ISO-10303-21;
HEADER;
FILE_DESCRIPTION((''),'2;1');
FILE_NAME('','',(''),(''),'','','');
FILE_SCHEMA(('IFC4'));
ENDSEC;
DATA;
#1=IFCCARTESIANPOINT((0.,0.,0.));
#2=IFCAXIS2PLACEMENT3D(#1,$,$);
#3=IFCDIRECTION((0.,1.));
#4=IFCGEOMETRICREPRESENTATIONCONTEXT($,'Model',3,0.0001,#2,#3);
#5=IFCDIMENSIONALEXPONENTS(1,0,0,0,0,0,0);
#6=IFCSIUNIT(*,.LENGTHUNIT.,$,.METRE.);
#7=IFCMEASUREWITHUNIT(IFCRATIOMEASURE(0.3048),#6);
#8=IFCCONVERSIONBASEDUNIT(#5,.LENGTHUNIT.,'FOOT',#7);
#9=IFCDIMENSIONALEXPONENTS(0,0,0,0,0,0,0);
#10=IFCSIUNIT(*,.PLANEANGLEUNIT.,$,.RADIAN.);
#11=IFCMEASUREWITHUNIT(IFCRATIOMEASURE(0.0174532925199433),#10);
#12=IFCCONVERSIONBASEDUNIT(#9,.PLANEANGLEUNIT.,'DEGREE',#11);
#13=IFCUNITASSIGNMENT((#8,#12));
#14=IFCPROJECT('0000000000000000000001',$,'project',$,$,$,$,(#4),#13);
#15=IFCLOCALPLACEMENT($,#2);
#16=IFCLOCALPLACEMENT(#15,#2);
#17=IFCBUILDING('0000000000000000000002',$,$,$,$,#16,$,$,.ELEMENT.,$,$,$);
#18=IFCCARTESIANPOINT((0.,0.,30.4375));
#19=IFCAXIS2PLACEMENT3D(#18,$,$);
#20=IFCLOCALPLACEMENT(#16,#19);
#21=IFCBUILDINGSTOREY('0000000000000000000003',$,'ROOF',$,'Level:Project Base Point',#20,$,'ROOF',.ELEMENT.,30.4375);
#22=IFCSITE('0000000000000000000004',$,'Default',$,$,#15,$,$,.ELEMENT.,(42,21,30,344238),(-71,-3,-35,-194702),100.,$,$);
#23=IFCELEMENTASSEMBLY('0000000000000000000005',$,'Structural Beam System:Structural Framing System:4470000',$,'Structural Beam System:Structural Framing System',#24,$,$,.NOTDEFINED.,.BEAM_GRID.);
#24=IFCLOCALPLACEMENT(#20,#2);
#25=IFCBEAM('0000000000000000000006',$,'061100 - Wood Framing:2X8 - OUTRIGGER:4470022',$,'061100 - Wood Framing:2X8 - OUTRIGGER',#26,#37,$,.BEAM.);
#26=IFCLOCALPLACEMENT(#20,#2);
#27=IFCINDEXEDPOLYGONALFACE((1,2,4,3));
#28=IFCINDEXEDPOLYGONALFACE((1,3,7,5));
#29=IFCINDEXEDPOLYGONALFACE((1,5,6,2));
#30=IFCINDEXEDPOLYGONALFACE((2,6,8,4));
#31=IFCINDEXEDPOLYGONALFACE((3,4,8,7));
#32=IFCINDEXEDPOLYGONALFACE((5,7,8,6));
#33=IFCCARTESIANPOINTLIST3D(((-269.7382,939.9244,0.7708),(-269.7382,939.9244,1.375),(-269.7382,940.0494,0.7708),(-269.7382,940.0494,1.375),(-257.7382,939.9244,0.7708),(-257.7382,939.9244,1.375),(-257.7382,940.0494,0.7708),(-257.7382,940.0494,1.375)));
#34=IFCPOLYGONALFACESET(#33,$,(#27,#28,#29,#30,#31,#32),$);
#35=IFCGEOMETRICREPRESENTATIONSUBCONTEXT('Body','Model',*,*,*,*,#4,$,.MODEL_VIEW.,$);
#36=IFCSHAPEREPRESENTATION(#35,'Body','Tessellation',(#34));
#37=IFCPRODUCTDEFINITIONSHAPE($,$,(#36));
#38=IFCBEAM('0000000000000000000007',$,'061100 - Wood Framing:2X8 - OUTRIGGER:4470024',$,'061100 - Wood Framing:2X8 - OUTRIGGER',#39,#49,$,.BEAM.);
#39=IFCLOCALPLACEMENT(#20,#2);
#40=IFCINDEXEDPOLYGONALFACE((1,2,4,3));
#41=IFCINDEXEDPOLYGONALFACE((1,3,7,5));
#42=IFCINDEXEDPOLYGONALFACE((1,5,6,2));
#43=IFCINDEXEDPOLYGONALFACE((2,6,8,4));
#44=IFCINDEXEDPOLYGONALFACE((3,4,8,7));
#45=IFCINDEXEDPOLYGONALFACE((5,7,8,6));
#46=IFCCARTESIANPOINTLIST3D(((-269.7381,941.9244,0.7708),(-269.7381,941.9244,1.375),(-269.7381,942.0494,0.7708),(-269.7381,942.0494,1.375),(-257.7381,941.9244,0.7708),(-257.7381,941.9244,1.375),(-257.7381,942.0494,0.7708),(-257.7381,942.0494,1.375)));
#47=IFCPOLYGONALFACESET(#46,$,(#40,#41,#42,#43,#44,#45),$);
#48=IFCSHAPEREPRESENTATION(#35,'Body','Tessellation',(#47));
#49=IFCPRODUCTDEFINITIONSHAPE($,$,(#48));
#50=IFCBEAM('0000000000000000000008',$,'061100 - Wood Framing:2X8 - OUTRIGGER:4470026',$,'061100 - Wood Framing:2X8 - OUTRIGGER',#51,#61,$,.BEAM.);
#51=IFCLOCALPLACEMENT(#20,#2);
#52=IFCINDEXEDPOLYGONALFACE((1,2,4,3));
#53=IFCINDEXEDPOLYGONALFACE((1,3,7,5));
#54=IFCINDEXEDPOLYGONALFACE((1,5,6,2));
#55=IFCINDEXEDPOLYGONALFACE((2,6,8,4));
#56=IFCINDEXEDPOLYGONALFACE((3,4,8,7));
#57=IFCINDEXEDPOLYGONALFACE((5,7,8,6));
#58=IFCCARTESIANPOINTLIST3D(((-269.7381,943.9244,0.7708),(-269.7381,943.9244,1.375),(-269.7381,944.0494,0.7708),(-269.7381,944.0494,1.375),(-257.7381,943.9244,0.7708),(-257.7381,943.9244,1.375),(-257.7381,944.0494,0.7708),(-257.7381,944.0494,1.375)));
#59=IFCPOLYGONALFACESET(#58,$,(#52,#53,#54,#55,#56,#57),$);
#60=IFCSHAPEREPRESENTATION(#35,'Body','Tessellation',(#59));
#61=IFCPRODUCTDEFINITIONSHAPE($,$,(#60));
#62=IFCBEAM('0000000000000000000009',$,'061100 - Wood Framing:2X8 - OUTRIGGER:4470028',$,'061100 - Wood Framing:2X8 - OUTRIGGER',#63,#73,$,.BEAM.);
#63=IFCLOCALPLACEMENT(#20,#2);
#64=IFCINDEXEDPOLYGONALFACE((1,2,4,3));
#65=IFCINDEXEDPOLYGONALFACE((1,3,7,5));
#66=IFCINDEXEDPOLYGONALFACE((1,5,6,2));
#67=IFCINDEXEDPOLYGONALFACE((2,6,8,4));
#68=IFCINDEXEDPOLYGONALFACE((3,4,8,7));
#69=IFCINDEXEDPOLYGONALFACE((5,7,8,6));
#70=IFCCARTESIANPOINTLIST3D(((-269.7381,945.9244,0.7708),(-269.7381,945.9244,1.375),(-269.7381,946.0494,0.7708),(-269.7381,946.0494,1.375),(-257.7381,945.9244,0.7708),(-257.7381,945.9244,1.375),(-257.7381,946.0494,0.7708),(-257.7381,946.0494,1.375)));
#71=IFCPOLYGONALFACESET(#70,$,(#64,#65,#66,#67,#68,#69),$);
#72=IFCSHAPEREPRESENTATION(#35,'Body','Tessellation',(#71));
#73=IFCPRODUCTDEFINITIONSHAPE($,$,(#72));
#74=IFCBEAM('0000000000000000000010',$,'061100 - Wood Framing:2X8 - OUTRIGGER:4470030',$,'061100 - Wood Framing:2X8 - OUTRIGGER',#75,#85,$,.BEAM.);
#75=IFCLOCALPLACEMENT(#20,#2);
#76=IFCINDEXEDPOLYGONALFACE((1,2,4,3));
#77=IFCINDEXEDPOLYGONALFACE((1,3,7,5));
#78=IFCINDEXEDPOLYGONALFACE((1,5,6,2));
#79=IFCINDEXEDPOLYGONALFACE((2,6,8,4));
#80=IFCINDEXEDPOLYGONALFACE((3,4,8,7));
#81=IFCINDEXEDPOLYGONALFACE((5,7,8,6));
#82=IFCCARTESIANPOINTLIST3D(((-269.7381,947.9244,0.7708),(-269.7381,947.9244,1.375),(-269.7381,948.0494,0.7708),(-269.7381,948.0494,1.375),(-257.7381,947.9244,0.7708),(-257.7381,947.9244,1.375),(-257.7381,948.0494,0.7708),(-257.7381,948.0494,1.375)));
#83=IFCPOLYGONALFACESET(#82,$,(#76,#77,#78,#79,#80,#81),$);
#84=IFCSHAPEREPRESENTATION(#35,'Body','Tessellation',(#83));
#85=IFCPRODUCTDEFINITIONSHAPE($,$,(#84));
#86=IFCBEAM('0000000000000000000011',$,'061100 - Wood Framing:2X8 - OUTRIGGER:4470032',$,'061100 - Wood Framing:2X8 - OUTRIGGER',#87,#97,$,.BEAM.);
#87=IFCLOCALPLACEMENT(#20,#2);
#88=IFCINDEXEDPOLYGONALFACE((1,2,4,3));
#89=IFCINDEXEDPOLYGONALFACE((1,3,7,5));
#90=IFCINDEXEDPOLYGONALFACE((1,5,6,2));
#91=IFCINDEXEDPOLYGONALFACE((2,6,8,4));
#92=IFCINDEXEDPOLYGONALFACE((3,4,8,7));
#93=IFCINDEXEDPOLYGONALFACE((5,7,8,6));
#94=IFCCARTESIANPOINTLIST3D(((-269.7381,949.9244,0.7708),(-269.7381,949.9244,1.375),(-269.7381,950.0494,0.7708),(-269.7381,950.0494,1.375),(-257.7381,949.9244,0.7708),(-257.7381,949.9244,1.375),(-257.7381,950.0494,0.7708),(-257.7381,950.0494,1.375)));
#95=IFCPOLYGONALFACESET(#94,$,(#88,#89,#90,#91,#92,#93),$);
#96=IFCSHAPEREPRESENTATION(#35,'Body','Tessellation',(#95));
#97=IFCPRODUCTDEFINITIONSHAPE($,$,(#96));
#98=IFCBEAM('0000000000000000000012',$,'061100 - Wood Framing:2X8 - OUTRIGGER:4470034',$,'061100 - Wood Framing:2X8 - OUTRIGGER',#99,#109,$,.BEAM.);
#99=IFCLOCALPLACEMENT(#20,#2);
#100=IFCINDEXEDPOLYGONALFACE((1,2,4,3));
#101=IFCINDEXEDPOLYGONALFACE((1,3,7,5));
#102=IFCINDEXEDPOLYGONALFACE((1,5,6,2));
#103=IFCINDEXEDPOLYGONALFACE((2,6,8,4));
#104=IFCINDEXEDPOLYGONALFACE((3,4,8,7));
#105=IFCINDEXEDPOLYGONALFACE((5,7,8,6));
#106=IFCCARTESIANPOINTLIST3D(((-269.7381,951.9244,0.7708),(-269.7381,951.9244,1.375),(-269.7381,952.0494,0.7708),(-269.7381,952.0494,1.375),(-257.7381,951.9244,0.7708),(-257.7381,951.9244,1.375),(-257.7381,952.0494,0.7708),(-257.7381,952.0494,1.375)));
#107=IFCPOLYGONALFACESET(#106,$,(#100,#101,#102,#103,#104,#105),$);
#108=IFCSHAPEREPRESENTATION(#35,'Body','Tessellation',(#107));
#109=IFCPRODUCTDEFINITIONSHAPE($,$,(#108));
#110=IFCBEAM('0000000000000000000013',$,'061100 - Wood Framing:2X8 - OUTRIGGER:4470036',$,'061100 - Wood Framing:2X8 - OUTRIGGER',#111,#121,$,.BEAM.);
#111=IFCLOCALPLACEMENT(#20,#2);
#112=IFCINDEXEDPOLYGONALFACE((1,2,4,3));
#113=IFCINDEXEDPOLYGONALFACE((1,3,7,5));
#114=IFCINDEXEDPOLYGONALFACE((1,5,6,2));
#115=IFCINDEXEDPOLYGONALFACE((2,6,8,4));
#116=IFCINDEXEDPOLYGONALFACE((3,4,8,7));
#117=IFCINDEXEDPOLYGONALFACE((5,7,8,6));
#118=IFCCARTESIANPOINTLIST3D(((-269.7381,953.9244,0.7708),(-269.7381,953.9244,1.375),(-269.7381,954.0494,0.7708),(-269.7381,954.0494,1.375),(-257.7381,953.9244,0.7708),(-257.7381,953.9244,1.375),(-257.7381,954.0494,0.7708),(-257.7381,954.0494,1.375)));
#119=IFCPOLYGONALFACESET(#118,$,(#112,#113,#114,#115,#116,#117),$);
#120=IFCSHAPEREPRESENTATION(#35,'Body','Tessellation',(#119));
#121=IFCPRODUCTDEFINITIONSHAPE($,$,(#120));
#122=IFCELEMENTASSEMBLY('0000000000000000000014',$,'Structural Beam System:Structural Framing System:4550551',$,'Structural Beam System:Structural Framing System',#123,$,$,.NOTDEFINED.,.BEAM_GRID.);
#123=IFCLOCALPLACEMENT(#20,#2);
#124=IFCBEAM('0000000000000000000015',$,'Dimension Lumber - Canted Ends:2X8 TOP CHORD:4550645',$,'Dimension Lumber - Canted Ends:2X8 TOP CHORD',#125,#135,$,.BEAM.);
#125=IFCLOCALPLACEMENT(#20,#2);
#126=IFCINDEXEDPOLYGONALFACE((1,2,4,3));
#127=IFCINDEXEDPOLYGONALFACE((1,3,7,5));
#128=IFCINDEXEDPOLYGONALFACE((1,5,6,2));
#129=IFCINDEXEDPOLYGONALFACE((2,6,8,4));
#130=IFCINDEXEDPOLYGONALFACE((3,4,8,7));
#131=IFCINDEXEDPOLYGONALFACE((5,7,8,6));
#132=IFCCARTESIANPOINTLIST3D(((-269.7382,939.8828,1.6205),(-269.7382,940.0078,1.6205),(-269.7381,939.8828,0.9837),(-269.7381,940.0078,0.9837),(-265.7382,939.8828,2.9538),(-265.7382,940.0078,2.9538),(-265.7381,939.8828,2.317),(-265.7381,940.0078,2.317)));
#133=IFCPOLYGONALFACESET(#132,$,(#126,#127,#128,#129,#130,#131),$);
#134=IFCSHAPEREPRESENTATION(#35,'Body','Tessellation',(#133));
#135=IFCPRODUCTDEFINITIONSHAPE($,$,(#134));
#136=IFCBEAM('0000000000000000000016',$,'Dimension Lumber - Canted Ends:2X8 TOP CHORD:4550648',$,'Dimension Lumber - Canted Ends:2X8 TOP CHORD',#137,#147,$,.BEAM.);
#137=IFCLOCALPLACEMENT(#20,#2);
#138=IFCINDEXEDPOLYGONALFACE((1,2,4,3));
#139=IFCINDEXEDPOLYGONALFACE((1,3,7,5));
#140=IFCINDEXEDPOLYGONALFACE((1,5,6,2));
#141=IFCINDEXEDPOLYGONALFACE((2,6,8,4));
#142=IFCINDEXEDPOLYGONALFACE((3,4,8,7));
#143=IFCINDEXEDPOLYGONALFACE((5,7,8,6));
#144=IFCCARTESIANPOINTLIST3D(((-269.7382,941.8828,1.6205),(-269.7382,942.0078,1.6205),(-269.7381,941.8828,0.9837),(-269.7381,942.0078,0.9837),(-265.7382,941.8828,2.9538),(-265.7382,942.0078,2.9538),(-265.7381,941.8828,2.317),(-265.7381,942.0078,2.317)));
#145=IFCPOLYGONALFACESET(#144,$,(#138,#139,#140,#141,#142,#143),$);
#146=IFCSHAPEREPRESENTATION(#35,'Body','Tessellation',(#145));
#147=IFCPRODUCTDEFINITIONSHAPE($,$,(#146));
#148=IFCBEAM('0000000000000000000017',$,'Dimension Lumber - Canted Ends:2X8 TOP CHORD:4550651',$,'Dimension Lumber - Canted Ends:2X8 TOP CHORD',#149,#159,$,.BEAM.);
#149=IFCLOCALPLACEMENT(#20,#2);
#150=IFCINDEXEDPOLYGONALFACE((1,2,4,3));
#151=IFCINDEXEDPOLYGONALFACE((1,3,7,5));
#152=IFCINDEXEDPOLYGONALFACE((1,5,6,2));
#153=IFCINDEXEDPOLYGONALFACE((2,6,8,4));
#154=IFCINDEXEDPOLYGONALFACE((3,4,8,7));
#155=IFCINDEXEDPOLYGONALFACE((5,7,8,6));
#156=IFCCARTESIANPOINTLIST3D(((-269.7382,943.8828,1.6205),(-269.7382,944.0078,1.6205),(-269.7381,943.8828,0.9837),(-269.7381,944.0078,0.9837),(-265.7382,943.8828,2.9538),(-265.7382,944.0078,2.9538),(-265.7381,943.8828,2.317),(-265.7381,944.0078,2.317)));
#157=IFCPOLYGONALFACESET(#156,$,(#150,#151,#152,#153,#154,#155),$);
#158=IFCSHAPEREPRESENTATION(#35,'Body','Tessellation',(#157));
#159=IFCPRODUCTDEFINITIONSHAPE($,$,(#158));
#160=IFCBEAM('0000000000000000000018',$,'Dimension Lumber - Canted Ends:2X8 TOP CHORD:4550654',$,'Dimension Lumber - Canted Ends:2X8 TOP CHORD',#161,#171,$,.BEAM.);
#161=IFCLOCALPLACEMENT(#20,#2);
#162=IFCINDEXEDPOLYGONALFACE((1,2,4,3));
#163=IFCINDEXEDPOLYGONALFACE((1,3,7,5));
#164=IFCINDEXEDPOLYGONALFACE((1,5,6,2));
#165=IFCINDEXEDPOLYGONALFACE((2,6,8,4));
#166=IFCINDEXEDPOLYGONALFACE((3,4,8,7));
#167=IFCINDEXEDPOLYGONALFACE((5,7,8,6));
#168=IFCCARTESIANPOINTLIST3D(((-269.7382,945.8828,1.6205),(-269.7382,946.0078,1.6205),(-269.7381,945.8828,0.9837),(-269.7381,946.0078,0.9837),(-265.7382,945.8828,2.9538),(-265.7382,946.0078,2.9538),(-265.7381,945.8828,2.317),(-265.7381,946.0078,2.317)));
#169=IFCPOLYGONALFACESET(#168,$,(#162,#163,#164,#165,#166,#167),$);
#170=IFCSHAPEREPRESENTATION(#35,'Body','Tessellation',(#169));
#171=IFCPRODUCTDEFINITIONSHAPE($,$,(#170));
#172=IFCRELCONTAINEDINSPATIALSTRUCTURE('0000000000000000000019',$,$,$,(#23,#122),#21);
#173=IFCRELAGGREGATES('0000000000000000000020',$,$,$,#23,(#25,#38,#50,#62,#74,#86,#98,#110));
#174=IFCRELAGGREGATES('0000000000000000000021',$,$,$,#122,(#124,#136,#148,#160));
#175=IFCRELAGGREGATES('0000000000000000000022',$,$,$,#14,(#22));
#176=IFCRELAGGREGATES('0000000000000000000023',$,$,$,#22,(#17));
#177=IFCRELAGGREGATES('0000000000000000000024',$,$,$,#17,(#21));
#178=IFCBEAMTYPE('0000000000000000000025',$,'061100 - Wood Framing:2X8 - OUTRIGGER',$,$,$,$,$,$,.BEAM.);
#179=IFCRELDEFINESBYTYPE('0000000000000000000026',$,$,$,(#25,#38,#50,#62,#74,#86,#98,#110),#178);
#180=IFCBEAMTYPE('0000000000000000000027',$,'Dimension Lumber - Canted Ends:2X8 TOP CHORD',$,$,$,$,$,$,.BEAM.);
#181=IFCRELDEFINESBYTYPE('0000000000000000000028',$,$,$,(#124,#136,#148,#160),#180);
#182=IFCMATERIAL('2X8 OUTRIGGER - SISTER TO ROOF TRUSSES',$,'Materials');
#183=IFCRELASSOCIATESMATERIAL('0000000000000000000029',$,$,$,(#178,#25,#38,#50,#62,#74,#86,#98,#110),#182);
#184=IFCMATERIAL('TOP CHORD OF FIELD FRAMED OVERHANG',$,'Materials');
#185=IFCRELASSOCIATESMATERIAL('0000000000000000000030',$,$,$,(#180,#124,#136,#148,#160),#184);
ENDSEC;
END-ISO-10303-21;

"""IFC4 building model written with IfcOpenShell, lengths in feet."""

from ifc_helpers import new_model, entity, si_unit, converted_unit, direction, frame, frame_2d, origin, origin_2d_with_axis, place, context, subcontext, project, spatial, rectangle, extrude, clip, halfspace, source, transform, mapped, material, material_profile, profile_set, profile_usage, type_object, type_shapes, element, aggregate, save


model = new_model("IFC4")

# Units and contexts
model_context = context("Model", 3, precision=0.0001, world=origin(), true_north=direction((0.0, 1.0)))
body_context = subcontext(model_context, "Body", "Model", "MODEL_VIEW")
ifc_project = project(units=[converted_unit("LENGTHUNIT", "FOOT", entity("IfcRatioMeasure", 0.3048), si_unit("LENGTHUNIT", "METRE"), dimensions=[1, 0, 0, 0, 0, 0, 0]), converted_unit("PLANEANGLEUNIT", "DEGREE", entity("IfcRatioMeasure", 0.0174532925199433), si_unit("PLANEANGLEUNIT", "RADIAN"), dimensions=[0, 0, 0, 0, 0, 0, 0])], contexts=[model_context])

# Site, building, storey
site_placement = place(None, origin())
site = spatial("IfcSite", under=ifc_project, at=site_placement, Name="Default", CompositionType="ELEMENT", RefLatitude=(42, 21, 30, 344238), RefLongitude=(-71, -3, -35, -194702), RefElevation=100.0)
building_placement = place(site_placement, origin())
building = spatial("IfcBuilding", under=site, at=building_placement, CompositionType="ELEMENT")
storey_placement = place(building_placement, frame((0.0, 0.0, 30.4375)))
storey = spatial("IfcBuildingStorey", under=building, at=storey_placement, Name="ROOF", ObjectType="Level:Project Base Point", LongName="ROOF", CompositionType="ELEMENT", Elevation=30.4375)

# Element assemblies, beams
assembly_1_placement = place(storey_placement, origin())
assembly_1 = element("IfcElementAssembly", 1, at=assembly_1_placement, inside=storey, Name="Structural Beam System:Structural Framing System:4470000", ObjectType="Structural Beam System:Structural Framing System", AssemblyPlace="NOTDEFINED", PredefinedType="BEAM_GRID")
ifc_material_1 = material(Name="2X8 OUTRIGGER - SISTER TO ROOF TRUSSES", Category="Materials")
ifc_material_profile_1 = material_profile(ifc_material_1, rectangle(XDim=0.6042, YDim=0.125, at=origin_2d_with_axis()), Name="2X8 - OUTRIGGER")
ifc_profile_set_1 = profile_set([ifc_material_profile_1], Name="2X8 - OUTRIGGER")
ifc_profile_usage_1 = profile_usage(ifc_profile_set_1, cardinal=8)
beam_type_1 = type_object("IfcBeamType", Name="061100 - Wood Framing:2X8 - OUTRIGGER", PredefinedType="BEAM", material=ifc_profile_set_1)
shared_shape_1 = source(origin(), body_context, "Body", "SweptSolid", [
    extrude(rectangle(XDim=0.6042, YDim=0.125, at=origin_2d_with_axis()), frame((-6.0, 0.0, 0.0), z_axis=(1.0, 0.0, 0.0), x_axis=(0.0, 0.0, -1.0)), (0.0, 0.0, 1.0), 12.0),
])
type_shapes(beam_type_1, [shared_shape_1])
beam_1_placement = place(assembly_1_placement, frame((-263.7382, 939.9869, 1.0729), z_axis=(0.0, 0.0, 1.0), x_axis=(-1.0, 0.0, 0.0)))
beam_1 = element("IfcBeam", 2, at=beam_1_placement, type_object=beam_type_1, material=ifc_profile_usage_1, Name="061100 - Wood Framing:2X8 - OUTRIGGER:4470022", ObjectType="061100 - Wood Framing:2X8 - OUTRIGGER", PredefinedType="BEAM", context=body_context, shape_type="MappedRepresentation", body=[
    mapped(shared_shape_1, transform((0.0, 0.0, 0.0), scale=1.0)),
])
ifc_profile_usage_2 = profile_usage(ifc_profile_set_1, cardinal=8)
beam_2_placement = place(assembly_1_placement, frame((-263.7381, 941.9869, 1.0729), z_axis=(0.0, 0.0, 1.0), x_axis=(-1.0, 0.0, 0.0)))
beam_2 = element("IfcBeam", 3, at=beam_2_placement, type_object=beam_type_1, material=ifc_profile_usage_2, Name="061100 - Wood Framing:2X8 - OUTRIGGER:4470024", ObjectType="061100 - Wood Framing:2X8 - OUTRIGGER", PredefinedType="BEAM", context=body_context, shape_type="MappedRepresentation", body=[
    mapped(shared_shape_1, transform((0.0, 0.0, 0.0), scale=1.0)),
])
ifc_profile_usage_3 = profile_usage(ifc_profile_set_1, cardinal=8)
beam_3_placement = place(assembly_1_placement, frame((-263.7381, 943.9869, 1.0729), z_axis=(0.0, 0.0, 1.0), x_axis=(-1.0, 0.0, 0.0)))
beam_3 = element("IfcBeam", 4, at=beam_3_placement, type_object=beam_type_1, material=ifc_profile_usage_3, Name="061100 - Wood Framing:2X8 - OUTRIGGER:4470026", ObjectType="061100 - Wood Framing:2X8 - OUTRIGGER", PredefinedType="BEAM", context=body_context, shape_type="MappedRepresentation", body=[
    mapped(shared_shape_1, transform((0.0, 0.0, 0.0), scale=1.0)),
])
ifc_profile_usage_4 = profile_usage(ifc_profile_set_1, cardinal=8)
beam_4_placement = place(assembly_1_placement, frame((-263.7381, 945.9869, 1.0729), z_axis=(0.0, 0.0, 1.0), x_axis=(-1.0, 0.0, 0.0)))
beam_4 = element("IfcBeam", 5, at=beam_4_placement, type_object=beam_type_1, material=ifc_profile_usage_4, Name="061100 - Wood Framing:2X8 - OUTRIGGER:4470028", ObjectType="061100 - Wood Framing:2X8 - OUTRIGGER", PredefinedType="BEAM", context=body_context, shape_type="MappedRepresentation", body=[
    mapped(shared_shape_1, transform((0.0, 0.0, 0.0), scale=1.0)),
])
ifc_profile_usage_5 = profile_usage(ifc_profile_set_1, cardinal=8)
beam_5_placement = place(assembly_1_placement, frame((-263.7381, 947.9869, 1.0729), z_axis=(0.0, 0.0, 1.0), x_axis=(-1.0, 0.0, 0.0)))
beam_5 = element("IfcBeam", 6, at=beam_5_placement, type_object=beam_type_1, material=ifc_profile_usage_5, Name="061100 - Wood Framing:2X8 - OUTRIGGER:4470030", ObjectType="061100 - Wood Framing:2X8 - OUTRIGGER", PredefinedType="BEAM", context=body_context, shape_type="MappedRepresentation", body=[
    mapped(shared_shape_1, transform((0.0, 0.0, 0.0), scale=1.0)),
])
ifc_profile_usage_6 = profile_usage(ifc_profile_set_1, cardinal=8)
beam_6_placement = place(assembly_1_placement, frame((-263.7381, 949.9869, 1.0729), z_axis=(0.0, 0.0, 1.0), x_axis=(-1.0, 0.0, 0.0)))
beam_6 = element("IfcBeam", 7, at=beam_6_placement, type_object=beam_type_1, material=ifc_profile_usage_6, Name="061100 - Wood Framing:2X8 - OUTRIGGER:4470032", ObjectType="061100 - Wood Framing:2X8 - OUTRIGGER", PredefinedType="BEAM", context=body_context, shape_type="MappedRepresentation", body=[
    mapped(shared_shape_1, transform((0.0, 0.0, 0.0), scale=1.0)),
])
ifc_profile_usage_7 = profile_usage(ifc_profile_set_1, cardinal=8)
beam_7_placement = place(assembly_1_placement, frame((-263.7381, 951.9869, 1.0729), z_axis=(0.0, 0.0, 1.0), x_axis=(-1.0, 0.0, 0.0)))
beam_7 = element("IfcBeam", 8, at=beam_7_placement, type_object=beam_type_1, material=ifc_profile_usage_7, Name="061100 - Wood Framing:2X8 - OUTRIGGER:4470034", ObjectType="061100 - Wood Framing:2X8 - OUTRIGGER", PredefinedType="BEAM", context=body_context, shape_type="MappedRepresentation", body=[
    mapped(shared_shape_1, transform((0.0, 0.0, 0.0), scale=1.0)),
])
ifc_profile_usage_8 = profile_usage(ifc_profile_set_1, cardinal=8)
beam_8_placement = place(assembly_1_placement, frame((-263.7381, 953.9869, 1.0729), z_axis=(0.0, 0.0, 1.0), x_axis=(-1.0, 0.0, 0.0)))
beam_8 = element("IfcBeam", 9, at=beam_8_placement, type_object=beam_type_1, material=ifc_profile_usage_8, Name="061100 - Wood Framing:2X8 - OUTRIGGER:4470036", ObjectType="061100 - Wood Framing:2X8 - OUTRIGGER", PredefinedType="BEAM", context=body_context, shape_type="MappedRepresentation", body=[
    mapped(shared_shape_1, transform((0.0, 0.0, 0.0), scale=1.0)),
])
aggregate(assembly_1, [beam_1, beam_2, beam_3, beam_4, beam_5, beam_6, beam_7, beam_8])
assembly_2_placement = place(storey_placement, origin())
assembly_2 = element("IfcElementAssembly", 10, at=assembly_2_placement, inside=storey, Name="Structural Beam System:Structural Framing System:4550551", ObjectType="Structural Beam System:Structural Framing System", AssemblyPlace="NOTDEFINED", PredefinedType="BEAM_GRID")
ifc_material_2 = material(Name="TOP CHORD OF FIELD FRAMED OVERHANG", Category="Materials")
ifc_material_profile_2 = material_profile(ifc_material_2, rectangle(XDim=0.6042, YDim=0.125, at=origin_2d_with_axis()), Name="2X8 TOP CHORD")
ifc_profile_set_2 = profile_set([ifc_material_profile_2], Name="2X8 TOP CHORD")
ifc_profile_usage_9 = profile_usage(ifc_profile_set_2, cardinal=8)
beam_type_2 = type_object("IfcBeamType", Name="Dimension Lumber - Canted Ends:2X8 TOP CHORD", PredefinedType="BEAM", material=ifc_profile_set_2)
shared_shape_2 = source(origin(), body_context, "Body", "Clipping", [
    clip(clip(extrude(rectangle(XDim=0.6042, YDim=0.125, at=frame_2d((0.0, 0.0), x_axis=(1.0, 0.0))), frame((-2.1082, 0.0, 0.0), z_axis=(1.0, 0.0, 0.0), x_axis=(0.0, 0.0, -1.0)), (0.0, 0.0, 1.0), 4.4177), halfspace(frame((2.1082, -0.0625, -0.3021), z_axis=(0.948711, 0.0, -0.316146), x_axis=(0.0, 1.0, 0.0)), False)), halfspace(frame((-1.9069, -0.0625, 0.3021), z_axis=(-0.948711, 0.0, 0.316146), x_axis=(0.0, 1.0, 0.0)), False)),
])
type_shapes(beam_type_2, [shared_shape_2])
beam_9_placement = place(assembly_2_placement, frame((-267.8337, 939.9453, 1.9369), z_axis=(-0.316228, 0.0, 0.948683), x_axis=(0.948683, 0.0, 0.316228)))
beam_9 = element("IfcBeam", 11, at=beam_9_placement, type_object=beam_type_2, material=ifc_profile_usage_9, Name="Dimension Lumber - Canted Ends:2X8 TOP CHORD:4550645", ObjectType="Dimension Lumber - Canted Ends:2X8 TOP CHORD", PredefinedType="BEAM", context=body_context, shape_type="MappedRepresentation", body=[
    mapped(shared_shape_2, transform((0.0, 0.0, 0.0), scale=1.0)),
])
ifc_profile_usage_10 = profile_usage(ifc_profile_set_2, cardinal=8)
beam_10_placement = place(assembly_2_placement, frame((-267.8337, 941.9453, 1.9369), z_axis=(-0.316228, 0.0, 0.948683), x_axis=(0.948683, 0.0, 0.316228)))
beam_10 = element("IfcBeam", 12, at=beam_10_placement, type_object=beam_type_2, material=ifc_profile_usage_10, Name="Dimension Lumber - Canted Ends:2X8 TOP CHORD:4550648", ObjectType="Dimension Lumber - Canted Ends:2X8 TOP CHORD", PredefinedType="BEAM", context=body_context, shape_type="MappedRepresentation", body=[
    mapped(shared_shape_2, transform((0.0, 0.0, 0.0), scale=1.0)),
])
ifc_profile_usage_11 = profile_usage(ifc_profile_set_2, cardinal=8)
beam_11_placement = place(assembly_2_placement, frame((-267.8337, 943.9453, 1.9369), z_axis=(-0.316228, 0.0, 0.948683), x_axis=(0.948683, 0.0, 0.316228)))
beam_11 = element("IfcBeam", 13, at=beam_11_placement, type_object=beam_type_2, material=ifc_profile_usage_11, Name="Dimension Lumber - Canted Ends:2X8 TOP CHORD:4550651", ObjectType="Dimension Lumber - Canted Ends:2X8 TOP CHORD", PredefinedType="BEAM", context=body_context, shape_type="MappedRepresentation", body=[
    mapped(shared_shape_2, transform((0.0, 0.0, 0.0), scale=1.0)),
])
ifc_profile_usage_12 = profile_usage(ifc_profile_set_2, cardinal=8)
beam_12_placement = place(assembly_2_placement, frame((-267.8337, 945.9453, 1.9369), z_axis=(-0.316228, 0.0, 0.948683), x_axis=(0.948683, 0.0, 0.316228)))
beam_12 = element("IfcBeam", 14, at=beam_12_placement, type_object=beam_type_2, material=ifc_profile_usage_12, Name="Dimension Lumber - Canted Ends:2X8 TOP CHORD:4550654", ObjectType="Dimension Lumber - Canted Ends:2X8 TOP CHORD", PredefinedType="BEAM", context=body_context, shape_type="MappedRepresentation", body=[
    mapped(shared_shape_2, transform((0.0, 0.0, 0.0), scale=1.0)),
])
aggregate(assembly_2, [beam_9, beam_10, beam_11, beam_12])

save(model, "model.ifc")
